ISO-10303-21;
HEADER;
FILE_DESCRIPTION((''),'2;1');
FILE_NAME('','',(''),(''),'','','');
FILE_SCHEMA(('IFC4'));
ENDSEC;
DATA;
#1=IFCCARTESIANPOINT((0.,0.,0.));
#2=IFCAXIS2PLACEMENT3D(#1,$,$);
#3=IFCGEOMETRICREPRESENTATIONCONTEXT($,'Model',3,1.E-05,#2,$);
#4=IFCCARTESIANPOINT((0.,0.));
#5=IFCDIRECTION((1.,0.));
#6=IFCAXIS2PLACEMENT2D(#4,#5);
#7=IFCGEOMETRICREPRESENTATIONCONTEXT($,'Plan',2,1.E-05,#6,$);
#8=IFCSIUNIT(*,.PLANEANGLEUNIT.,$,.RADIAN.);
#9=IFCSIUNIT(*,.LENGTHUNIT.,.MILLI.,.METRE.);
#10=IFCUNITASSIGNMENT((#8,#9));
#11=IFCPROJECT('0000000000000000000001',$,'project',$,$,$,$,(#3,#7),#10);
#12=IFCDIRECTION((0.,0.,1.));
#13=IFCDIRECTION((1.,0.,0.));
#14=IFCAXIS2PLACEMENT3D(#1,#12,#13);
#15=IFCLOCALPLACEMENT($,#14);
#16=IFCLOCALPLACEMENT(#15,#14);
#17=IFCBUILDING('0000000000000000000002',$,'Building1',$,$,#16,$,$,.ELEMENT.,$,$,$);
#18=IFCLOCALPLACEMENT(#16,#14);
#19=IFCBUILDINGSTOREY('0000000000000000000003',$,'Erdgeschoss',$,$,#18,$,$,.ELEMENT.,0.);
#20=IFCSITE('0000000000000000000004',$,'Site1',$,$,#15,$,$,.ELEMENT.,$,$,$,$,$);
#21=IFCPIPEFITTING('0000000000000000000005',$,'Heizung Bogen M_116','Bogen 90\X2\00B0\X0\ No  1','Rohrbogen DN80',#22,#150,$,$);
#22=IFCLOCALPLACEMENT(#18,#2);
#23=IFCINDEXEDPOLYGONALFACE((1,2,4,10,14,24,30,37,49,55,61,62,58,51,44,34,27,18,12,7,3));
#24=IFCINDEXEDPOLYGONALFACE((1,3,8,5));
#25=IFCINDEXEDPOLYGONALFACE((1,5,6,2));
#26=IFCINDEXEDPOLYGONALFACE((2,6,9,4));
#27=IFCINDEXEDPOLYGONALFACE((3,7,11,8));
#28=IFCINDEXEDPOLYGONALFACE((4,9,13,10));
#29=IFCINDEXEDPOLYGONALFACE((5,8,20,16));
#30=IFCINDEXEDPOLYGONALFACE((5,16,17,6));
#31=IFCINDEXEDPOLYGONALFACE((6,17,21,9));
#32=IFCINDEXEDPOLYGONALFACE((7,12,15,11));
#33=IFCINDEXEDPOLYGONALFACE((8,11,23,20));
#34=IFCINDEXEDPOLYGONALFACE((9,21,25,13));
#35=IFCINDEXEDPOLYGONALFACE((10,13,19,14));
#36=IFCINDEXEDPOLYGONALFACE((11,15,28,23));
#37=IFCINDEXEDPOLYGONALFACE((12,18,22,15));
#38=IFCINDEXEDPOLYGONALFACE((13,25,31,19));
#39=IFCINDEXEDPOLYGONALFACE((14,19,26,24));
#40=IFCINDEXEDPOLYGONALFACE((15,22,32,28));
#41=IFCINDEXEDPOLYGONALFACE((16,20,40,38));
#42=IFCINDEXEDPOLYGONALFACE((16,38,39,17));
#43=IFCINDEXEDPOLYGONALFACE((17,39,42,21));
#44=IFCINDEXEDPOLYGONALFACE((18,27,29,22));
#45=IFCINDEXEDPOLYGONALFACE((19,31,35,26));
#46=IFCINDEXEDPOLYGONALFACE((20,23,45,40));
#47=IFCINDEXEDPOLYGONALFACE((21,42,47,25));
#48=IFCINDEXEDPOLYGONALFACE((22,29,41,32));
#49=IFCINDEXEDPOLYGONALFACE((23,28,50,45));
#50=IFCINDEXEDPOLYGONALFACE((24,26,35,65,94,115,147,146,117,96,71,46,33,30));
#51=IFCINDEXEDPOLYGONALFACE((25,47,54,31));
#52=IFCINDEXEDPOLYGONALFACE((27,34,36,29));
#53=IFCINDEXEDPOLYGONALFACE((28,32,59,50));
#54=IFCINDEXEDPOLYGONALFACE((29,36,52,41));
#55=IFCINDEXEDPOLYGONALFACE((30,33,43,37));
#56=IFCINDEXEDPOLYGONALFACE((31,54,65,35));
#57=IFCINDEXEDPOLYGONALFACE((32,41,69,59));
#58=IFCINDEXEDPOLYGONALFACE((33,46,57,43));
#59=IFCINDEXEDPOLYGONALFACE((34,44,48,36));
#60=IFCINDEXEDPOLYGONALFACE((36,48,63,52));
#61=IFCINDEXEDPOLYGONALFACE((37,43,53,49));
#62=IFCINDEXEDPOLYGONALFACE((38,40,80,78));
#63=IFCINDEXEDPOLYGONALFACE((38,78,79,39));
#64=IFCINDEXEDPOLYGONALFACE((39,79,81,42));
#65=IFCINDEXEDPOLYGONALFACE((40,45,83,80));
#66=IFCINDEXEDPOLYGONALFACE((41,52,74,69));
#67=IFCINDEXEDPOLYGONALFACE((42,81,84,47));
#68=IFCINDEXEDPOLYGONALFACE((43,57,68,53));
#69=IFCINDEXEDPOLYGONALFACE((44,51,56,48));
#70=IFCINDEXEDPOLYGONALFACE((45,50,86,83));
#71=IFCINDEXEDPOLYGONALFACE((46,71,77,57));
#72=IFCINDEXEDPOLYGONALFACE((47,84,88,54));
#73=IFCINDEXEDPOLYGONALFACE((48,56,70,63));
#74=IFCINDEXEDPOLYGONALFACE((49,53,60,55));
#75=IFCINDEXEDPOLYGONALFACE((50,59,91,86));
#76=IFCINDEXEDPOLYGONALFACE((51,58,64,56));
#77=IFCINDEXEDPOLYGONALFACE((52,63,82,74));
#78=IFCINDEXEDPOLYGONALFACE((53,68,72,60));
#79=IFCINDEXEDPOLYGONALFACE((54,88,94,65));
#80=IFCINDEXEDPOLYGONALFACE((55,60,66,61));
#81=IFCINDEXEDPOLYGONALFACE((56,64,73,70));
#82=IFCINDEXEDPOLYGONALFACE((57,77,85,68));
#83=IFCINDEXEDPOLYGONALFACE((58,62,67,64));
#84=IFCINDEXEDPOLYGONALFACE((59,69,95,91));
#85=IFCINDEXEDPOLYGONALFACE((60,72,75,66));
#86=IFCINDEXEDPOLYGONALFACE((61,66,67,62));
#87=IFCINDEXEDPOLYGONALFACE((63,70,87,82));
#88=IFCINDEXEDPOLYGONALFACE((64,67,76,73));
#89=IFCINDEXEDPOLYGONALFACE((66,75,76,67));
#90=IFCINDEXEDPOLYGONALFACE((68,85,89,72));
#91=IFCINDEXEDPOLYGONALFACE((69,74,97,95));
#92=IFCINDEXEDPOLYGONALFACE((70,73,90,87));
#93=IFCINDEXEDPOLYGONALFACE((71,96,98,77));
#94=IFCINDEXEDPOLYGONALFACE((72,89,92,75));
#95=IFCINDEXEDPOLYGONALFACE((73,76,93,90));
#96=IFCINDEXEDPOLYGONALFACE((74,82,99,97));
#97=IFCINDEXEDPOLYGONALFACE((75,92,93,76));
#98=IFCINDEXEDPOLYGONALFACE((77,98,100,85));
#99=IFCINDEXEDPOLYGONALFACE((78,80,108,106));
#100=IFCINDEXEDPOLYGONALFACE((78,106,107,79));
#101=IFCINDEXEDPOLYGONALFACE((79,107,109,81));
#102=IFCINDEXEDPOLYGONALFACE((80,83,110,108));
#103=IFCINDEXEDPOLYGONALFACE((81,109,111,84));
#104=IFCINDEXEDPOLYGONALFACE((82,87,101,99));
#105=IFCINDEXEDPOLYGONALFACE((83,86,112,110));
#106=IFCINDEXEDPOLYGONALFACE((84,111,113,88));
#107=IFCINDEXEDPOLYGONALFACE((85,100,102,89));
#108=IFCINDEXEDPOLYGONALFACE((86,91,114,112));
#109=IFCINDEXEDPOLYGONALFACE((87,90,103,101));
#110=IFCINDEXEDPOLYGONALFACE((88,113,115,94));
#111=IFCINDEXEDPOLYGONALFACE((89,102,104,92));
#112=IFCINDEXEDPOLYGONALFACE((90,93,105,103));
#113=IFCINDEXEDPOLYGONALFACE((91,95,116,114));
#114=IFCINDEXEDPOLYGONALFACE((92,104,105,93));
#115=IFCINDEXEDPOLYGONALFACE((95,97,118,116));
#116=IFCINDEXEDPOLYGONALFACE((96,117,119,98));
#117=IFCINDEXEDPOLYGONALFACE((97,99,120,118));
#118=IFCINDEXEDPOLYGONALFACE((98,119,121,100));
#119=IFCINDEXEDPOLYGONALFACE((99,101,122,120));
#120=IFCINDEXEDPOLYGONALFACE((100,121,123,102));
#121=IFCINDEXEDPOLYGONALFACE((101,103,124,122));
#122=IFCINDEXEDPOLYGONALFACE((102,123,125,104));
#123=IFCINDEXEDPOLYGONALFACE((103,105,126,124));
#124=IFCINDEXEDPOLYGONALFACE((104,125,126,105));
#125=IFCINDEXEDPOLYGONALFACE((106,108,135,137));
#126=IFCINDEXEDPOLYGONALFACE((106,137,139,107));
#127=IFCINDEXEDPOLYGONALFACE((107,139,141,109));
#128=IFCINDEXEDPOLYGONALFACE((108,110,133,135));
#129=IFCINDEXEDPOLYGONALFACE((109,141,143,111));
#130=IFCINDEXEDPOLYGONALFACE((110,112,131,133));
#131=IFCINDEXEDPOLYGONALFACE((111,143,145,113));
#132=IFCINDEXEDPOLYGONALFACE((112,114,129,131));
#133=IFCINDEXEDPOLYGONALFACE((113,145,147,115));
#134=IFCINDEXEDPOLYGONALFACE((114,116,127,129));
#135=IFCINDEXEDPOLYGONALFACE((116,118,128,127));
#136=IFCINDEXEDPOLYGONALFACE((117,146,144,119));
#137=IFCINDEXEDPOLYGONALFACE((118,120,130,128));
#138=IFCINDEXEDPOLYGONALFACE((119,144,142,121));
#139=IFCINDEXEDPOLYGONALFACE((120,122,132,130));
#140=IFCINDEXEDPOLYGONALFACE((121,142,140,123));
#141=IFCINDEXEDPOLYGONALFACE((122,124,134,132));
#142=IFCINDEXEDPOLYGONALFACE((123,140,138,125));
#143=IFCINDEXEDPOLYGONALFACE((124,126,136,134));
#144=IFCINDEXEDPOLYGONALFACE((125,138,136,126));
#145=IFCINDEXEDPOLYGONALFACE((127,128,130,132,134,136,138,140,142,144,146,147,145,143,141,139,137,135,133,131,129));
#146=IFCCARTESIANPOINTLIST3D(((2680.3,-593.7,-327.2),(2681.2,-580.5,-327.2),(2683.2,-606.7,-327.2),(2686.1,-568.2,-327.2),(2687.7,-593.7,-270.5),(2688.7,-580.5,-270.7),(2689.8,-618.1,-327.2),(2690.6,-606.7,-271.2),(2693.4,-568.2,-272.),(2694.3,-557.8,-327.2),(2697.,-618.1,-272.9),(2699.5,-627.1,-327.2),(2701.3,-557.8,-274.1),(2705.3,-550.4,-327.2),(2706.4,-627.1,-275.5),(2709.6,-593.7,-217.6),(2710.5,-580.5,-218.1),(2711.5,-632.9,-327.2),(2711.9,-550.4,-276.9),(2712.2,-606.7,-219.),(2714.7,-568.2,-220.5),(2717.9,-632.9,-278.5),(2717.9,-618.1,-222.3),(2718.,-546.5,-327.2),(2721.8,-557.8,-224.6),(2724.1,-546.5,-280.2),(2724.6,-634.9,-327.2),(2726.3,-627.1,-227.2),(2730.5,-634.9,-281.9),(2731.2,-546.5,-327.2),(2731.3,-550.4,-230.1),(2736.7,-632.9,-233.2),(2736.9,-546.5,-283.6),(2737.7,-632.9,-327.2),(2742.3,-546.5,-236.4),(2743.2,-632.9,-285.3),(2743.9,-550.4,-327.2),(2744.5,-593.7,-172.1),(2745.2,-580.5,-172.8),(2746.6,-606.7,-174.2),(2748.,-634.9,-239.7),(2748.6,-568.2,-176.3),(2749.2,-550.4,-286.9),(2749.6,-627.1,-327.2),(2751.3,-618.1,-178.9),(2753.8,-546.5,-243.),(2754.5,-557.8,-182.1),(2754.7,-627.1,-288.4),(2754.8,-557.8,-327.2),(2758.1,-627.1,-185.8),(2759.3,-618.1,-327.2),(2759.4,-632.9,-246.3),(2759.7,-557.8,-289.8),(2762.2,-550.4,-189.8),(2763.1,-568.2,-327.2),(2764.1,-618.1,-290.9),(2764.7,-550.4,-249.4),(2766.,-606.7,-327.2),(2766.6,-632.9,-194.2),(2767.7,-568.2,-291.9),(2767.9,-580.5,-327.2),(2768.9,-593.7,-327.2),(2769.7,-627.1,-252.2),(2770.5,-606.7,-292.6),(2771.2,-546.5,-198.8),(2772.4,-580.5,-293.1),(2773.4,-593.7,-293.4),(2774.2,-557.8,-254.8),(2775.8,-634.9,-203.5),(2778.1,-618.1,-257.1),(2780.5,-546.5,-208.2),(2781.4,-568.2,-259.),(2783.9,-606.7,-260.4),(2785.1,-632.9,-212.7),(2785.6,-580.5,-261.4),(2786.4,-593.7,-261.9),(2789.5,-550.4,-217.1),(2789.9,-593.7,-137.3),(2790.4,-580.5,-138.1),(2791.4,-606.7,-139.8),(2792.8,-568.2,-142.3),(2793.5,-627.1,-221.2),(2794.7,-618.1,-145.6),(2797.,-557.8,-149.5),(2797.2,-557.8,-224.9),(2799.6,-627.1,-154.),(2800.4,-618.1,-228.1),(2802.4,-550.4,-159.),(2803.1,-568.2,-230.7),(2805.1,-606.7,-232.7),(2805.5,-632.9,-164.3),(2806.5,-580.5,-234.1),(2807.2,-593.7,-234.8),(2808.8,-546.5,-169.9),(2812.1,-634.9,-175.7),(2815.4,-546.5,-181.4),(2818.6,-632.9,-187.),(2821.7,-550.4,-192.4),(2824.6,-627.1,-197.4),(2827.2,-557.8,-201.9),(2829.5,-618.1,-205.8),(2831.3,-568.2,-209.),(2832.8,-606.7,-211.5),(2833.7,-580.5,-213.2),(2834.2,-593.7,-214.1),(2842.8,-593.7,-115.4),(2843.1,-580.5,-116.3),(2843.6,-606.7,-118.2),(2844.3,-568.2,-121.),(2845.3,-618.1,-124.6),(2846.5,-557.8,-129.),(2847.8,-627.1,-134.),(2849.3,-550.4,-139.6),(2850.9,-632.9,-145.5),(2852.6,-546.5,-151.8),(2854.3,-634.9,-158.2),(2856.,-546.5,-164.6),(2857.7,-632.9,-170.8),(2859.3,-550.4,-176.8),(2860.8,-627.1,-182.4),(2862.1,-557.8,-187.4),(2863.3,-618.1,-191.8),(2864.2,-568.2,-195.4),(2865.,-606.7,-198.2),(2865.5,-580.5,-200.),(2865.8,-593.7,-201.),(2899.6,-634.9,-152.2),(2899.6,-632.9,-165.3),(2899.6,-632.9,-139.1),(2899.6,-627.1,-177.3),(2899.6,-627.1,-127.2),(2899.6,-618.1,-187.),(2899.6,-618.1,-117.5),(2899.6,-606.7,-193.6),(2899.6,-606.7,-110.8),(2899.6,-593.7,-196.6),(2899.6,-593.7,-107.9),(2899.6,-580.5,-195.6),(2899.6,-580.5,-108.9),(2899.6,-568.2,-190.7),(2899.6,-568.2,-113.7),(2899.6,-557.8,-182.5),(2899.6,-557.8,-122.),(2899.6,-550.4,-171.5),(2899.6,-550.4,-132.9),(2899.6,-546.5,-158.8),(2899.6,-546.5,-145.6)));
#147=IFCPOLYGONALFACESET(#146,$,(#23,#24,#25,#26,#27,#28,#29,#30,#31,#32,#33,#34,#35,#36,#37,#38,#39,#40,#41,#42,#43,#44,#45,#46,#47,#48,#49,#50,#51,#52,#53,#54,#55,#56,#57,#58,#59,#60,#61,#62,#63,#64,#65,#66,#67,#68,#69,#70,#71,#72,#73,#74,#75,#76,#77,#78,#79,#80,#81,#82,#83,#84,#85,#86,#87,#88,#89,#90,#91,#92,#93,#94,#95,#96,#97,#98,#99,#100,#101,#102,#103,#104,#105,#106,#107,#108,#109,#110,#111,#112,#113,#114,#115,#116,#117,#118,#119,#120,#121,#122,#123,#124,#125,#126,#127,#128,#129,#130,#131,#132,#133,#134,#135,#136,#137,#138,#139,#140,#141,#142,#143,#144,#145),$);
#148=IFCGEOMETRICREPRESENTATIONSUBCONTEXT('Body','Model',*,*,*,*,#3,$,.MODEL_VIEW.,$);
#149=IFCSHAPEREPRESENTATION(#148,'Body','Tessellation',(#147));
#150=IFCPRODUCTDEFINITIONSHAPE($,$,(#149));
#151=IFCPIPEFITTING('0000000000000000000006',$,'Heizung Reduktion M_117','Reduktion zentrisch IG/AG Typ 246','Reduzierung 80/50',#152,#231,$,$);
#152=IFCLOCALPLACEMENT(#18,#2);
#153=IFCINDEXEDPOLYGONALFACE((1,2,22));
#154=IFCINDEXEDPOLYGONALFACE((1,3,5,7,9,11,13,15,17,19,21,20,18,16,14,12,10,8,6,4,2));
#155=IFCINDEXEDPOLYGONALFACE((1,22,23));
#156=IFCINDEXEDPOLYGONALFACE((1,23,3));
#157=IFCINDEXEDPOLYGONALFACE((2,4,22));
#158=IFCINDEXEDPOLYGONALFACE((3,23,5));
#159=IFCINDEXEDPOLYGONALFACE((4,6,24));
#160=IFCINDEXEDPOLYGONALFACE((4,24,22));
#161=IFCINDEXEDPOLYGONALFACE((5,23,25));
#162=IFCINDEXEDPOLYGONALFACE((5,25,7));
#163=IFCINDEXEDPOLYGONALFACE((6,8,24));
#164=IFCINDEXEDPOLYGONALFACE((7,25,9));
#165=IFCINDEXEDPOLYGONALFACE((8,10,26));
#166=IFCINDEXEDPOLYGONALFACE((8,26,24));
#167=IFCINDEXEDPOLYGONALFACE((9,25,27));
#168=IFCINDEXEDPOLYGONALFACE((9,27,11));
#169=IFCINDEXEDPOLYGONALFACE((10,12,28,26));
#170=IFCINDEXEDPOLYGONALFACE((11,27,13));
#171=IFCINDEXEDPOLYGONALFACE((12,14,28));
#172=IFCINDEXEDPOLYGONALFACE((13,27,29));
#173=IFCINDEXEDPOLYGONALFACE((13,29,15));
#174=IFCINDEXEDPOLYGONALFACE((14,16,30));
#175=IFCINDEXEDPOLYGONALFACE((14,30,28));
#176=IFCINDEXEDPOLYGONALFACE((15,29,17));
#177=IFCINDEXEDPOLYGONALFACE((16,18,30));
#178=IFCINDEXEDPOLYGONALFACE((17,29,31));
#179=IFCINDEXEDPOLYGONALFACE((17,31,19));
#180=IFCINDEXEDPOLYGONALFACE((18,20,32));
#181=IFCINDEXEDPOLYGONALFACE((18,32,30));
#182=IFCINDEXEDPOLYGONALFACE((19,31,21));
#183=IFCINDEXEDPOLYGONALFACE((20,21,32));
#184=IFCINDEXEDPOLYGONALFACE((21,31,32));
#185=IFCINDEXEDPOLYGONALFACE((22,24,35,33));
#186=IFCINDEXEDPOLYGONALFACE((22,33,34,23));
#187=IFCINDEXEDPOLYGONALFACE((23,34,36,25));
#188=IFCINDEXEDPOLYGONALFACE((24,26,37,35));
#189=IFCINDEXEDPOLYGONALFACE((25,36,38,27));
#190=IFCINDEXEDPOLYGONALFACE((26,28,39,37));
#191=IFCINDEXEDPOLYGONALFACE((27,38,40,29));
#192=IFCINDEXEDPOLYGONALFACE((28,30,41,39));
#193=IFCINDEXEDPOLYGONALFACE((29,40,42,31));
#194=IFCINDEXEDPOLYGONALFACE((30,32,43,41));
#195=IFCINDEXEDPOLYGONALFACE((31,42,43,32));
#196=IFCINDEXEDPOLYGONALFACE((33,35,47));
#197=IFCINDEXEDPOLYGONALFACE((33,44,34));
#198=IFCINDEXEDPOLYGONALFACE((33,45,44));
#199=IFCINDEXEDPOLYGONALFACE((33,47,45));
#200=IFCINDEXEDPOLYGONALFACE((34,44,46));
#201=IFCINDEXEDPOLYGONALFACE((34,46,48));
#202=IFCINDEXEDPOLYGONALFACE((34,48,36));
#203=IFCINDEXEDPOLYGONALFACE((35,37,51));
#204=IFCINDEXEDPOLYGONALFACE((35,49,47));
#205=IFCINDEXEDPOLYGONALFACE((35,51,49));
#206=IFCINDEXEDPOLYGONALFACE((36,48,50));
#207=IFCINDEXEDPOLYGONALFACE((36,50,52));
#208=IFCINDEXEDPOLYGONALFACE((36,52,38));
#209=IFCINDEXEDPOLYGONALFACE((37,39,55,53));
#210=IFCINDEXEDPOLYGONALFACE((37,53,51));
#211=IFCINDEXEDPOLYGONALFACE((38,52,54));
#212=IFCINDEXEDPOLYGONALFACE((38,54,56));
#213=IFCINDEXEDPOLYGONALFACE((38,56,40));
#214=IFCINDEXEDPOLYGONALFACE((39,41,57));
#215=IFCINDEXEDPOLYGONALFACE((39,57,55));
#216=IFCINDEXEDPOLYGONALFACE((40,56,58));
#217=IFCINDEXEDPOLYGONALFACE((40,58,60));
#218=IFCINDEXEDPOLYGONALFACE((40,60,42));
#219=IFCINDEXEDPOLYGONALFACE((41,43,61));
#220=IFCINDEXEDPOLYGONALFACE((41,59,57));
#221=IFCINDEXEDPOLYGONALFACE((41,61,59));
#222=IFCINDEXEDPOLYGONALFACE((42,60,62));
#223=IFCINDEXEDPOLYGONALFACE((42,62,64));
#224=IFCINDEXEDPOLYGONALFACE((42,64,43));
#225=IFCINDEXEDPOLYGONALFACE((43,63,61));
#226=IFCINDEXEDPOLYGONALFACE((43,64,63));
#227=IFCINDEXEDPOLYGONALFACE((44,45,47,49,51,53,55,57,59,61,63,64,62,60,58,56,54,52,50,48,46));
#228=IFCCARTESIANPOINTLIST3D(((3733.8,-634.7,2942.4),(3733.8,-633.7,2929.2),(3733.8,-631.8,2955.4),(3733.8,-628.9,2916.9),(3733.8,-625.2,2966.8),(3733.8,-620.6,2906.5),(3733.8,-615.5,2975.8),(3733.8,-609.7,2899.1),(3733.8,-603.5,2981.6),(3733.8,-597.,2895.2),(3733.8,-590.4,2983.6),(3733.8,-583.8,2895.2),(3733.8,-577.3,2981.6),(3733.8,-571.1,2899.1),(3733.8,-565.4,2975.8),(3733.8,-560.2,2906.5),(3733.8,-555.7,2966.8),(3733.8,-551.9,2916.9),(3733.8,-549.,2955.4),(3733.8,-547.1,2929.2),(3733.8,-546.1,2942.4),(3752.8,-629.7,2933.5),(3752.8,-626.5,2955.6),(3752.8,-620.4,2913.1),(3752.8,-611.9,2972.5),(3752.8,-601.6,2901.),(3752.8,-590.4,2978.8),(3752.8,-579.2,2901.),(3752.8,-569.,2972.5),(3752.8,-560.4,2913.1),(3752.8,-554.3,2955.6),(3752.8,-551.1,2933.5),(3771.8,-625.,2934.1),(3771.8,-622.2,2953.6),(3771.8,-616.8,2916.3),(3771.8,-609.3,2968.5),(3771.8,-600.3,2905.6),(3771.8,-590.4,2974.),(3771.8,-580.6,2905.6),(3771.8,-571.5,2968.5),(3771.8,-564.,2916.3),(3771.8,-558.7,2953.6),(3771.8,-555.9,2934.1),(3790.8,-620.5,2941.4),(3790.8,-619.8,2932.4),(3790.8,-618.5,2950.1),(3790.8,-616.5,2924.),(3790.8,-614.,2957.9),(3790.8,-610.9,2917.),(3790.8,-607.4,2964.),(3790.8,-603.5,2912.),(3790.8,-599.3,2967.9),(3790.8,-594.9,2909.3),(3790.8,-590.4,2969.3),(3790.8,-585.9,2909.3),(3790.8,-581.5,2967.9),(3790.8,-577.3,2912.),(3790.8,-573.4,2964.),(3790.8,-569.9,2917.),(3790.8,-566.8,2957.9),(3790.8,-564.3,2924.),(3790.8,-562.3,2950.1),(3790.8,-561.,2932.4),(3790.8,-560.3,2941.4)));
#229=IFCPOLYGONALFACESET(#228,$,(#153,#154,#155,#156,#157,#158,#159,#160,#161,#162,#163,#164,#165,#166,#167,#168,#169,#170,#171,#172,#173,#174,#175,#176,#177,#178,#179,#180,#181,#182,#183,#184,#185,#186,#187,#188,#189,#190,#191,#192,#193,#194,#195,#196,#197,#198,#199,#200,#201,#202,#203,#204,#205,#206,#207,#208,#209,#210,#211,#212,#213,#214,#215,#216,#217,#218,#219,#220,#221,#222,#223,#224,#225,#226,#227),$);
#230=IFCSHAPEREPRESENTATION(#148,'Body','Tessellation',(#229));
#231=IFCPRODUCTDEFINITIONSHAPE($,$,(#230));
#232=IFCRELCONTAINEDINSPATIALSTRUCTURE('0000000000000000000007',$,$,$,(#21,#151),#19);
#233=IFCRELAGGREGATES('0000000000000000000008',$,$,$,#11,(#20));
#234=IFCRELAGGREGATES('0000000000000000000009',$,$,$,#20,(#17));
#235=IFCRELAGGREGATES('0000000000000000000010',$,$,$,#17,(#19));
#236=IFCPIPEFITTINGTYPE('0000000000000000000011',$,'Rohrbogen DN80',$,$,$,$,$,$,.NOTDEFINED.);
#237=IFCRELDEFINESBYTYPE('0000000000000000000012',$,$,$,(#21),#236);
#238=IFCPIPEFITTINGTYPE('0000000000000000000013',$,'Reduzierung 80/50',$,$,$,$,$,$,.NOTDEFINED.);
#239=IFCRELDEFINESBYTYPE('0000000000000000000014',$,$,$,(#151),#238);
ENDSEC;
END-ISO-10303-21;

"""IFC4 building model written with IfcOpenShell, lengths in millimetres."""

from ifc_helpers import new_model, entity, si_unit, frame, origin, origin_with_axes, origin_2d_with_axis, place, context, subcontext, project, spatial, shape, source, transform, mapped, type_object, element, save


model = new_model("IFC4")

# Units and contexts
model_context = context("Model", 3, precision=1e-05, world=origin())
plan_context = context("Plan", 2, precision=1e-05, world=origin_2d_with_axis())
body_context = subcontext(model_context, "Body", "Model", "MODEL_VIEW")
ifc_project = project(units=[si_unit("PLANEANGLEUNIT", "RADIAN"), si_unit("LENGTHUNIT", "METRE", prefix="MILLI")], contexts=[model_context, plan_context])

# Site, building, storey
site_placement = place(None, origin_with_axes())
site = spatial("IfcSite", under=ifc_project, at=site_placement, Name="Site1", CompositionType="ELEMENT")
building_placement = place(site_placement, origin_with_axes())
building = spatial("IfcBuilding", under=site, at=building_placement, Name="Building1", CompositionType="ELEMENT")
storey_placement = place(building_placement, origin_with_axes())
storey = spatial("IfcBuildingStorey", under=building, at=storey_placement, Name="Erdgeschoss", CompositionType="ELEMENT", Elevation=0.0)

# Pipe fittings
pipe_fitting_type_1 = type_object("IfcPipeFittingType", Name="Rohrbogen DN80", PredefinedType="NOTDEFINED")
ifc_direction_1 = entity("IfcDirection", [-1.0, 0.0, 0.0])
shared_shape_1 = source(origin_with_axes(), body_context, "Body", "SolidModel", [
    entity("IfcRevolvedAreaSolid", entity("IfcCircleProfileDef", "AREA", None, entity("IfcAxis2Placement2D", entity("IfcCartesianPoint", [0.0, 0.0]), entity("IfcDirection", [1.0, 0.0])), 44.5), entity("IfcAxis2Placement3D", entity("IfcCartesianPoint", [109.7, -65.3, 0.0]), ifc_direction_1, entity("IfcDirection", [0.0, 0.0, 1.0])), entity("IfcAxis1Placement", entity("IfcCartesianPoint", [0.0, 175.0, 0.0]), ifc_direction_1), 1.570796),
])
pipe_fitting_1_placement = place(storey_placement, frame((2789.9, -590.4, -217.5), z_axis=(0.0, 0.0, 1.0), x_axis=(1.0, 0.0, 0.0)))
element("IfcPipeFitting", 1, at=pipe_fitting_1_placement, inside=storey, type_object=pipe_fitting_type_1, Name="Heizung Bogen M_116", Description="Bogen 90° No  1", ObjectType="Rohrbogen DN80", shapes=[
    shape(body_context, "Body", "MappedRepresentation", [mapped(shared_shape_1, transform((0.0, 0.0, 0.0), x_axis=(0.0, 0.0, -1.0), y_axis=(1.0, 0.0, 0.0), z_axis=(0.0, -1.0, 0.0), scale=1.0))]),
    shape(body_context, "Body", "MappedRepresentation", [mapped(shared_shape_1, transform((0.0, 0.0, 0.0), x_axis=(0.0, 0.0, -1.0), y_axis=(1.0, 0.0, 0.0), z_axis=(0.0, -1.0, 0.0), scale=1.0))]),
])
pipe_fitting_type_2 = type_object("IfcPipeFittingType", Name="Reduzierung 80/50", PredefinedType="NOTDEFINED")
axis2_placement2_d = entity("IfcAxis2Placement2D", entity("IfcCartesianPoint", [0.0, 0.0]), entity("IfcDirection", [1.0, 0.0]))
ifc_direction_2 = entity("IfcDirection", [0.0, 0.0, 1.0])
shared_shape_2 = source(origin_with_axes(), body_context, "Body", "SolidModel", [
    entity("IfcExtrudedAreaSolidTapered", entity("IfcCircleProfileDef", "AREA", None, axis2_placement2_d, 44.5), entity("IfcAxis2Placement3D", entity("IfcCartesianPoint", [-28.5, -0.1, 0.0]), entity("IfcDirection", [1.0, 0.0, 0.0]), ifc_direction_2), ifc_direction_2, 57.0, entity("IfcCircleProfileDef", "AREA", None, axis2_placement2_d, 30.1)),
])
pipe_fitting_2_placement = place(storey_placement, frame((3762.3, -590.3, 2939.1), z_axis=(0.0, 0.0, 1.0), x_axis=(1.0, 0.0, 0.0)))
element("IfcPipeFitting", 2, at=pipe_fitting_2_placement, inside=storey, type_object=pipe_fitting_type_2, Name="Heizung Reduktion M_117", Description="Reduktion zentrisch IG/AG Typ 246", ObjectType="Reduzierung 80/50", context=body_context, shape_type="MappedRepresentation", body=[
    mapped(shared_shape_2, transform((0.0, 0.0, 0.0), x_axis=(1.0, 0.0, 0.0), y_axis=(0.0, 1.0, 0.0), z_axis=(0.0, 0.0, 1.0), scale=1.0)),
])

save(model, "model.ifc")
